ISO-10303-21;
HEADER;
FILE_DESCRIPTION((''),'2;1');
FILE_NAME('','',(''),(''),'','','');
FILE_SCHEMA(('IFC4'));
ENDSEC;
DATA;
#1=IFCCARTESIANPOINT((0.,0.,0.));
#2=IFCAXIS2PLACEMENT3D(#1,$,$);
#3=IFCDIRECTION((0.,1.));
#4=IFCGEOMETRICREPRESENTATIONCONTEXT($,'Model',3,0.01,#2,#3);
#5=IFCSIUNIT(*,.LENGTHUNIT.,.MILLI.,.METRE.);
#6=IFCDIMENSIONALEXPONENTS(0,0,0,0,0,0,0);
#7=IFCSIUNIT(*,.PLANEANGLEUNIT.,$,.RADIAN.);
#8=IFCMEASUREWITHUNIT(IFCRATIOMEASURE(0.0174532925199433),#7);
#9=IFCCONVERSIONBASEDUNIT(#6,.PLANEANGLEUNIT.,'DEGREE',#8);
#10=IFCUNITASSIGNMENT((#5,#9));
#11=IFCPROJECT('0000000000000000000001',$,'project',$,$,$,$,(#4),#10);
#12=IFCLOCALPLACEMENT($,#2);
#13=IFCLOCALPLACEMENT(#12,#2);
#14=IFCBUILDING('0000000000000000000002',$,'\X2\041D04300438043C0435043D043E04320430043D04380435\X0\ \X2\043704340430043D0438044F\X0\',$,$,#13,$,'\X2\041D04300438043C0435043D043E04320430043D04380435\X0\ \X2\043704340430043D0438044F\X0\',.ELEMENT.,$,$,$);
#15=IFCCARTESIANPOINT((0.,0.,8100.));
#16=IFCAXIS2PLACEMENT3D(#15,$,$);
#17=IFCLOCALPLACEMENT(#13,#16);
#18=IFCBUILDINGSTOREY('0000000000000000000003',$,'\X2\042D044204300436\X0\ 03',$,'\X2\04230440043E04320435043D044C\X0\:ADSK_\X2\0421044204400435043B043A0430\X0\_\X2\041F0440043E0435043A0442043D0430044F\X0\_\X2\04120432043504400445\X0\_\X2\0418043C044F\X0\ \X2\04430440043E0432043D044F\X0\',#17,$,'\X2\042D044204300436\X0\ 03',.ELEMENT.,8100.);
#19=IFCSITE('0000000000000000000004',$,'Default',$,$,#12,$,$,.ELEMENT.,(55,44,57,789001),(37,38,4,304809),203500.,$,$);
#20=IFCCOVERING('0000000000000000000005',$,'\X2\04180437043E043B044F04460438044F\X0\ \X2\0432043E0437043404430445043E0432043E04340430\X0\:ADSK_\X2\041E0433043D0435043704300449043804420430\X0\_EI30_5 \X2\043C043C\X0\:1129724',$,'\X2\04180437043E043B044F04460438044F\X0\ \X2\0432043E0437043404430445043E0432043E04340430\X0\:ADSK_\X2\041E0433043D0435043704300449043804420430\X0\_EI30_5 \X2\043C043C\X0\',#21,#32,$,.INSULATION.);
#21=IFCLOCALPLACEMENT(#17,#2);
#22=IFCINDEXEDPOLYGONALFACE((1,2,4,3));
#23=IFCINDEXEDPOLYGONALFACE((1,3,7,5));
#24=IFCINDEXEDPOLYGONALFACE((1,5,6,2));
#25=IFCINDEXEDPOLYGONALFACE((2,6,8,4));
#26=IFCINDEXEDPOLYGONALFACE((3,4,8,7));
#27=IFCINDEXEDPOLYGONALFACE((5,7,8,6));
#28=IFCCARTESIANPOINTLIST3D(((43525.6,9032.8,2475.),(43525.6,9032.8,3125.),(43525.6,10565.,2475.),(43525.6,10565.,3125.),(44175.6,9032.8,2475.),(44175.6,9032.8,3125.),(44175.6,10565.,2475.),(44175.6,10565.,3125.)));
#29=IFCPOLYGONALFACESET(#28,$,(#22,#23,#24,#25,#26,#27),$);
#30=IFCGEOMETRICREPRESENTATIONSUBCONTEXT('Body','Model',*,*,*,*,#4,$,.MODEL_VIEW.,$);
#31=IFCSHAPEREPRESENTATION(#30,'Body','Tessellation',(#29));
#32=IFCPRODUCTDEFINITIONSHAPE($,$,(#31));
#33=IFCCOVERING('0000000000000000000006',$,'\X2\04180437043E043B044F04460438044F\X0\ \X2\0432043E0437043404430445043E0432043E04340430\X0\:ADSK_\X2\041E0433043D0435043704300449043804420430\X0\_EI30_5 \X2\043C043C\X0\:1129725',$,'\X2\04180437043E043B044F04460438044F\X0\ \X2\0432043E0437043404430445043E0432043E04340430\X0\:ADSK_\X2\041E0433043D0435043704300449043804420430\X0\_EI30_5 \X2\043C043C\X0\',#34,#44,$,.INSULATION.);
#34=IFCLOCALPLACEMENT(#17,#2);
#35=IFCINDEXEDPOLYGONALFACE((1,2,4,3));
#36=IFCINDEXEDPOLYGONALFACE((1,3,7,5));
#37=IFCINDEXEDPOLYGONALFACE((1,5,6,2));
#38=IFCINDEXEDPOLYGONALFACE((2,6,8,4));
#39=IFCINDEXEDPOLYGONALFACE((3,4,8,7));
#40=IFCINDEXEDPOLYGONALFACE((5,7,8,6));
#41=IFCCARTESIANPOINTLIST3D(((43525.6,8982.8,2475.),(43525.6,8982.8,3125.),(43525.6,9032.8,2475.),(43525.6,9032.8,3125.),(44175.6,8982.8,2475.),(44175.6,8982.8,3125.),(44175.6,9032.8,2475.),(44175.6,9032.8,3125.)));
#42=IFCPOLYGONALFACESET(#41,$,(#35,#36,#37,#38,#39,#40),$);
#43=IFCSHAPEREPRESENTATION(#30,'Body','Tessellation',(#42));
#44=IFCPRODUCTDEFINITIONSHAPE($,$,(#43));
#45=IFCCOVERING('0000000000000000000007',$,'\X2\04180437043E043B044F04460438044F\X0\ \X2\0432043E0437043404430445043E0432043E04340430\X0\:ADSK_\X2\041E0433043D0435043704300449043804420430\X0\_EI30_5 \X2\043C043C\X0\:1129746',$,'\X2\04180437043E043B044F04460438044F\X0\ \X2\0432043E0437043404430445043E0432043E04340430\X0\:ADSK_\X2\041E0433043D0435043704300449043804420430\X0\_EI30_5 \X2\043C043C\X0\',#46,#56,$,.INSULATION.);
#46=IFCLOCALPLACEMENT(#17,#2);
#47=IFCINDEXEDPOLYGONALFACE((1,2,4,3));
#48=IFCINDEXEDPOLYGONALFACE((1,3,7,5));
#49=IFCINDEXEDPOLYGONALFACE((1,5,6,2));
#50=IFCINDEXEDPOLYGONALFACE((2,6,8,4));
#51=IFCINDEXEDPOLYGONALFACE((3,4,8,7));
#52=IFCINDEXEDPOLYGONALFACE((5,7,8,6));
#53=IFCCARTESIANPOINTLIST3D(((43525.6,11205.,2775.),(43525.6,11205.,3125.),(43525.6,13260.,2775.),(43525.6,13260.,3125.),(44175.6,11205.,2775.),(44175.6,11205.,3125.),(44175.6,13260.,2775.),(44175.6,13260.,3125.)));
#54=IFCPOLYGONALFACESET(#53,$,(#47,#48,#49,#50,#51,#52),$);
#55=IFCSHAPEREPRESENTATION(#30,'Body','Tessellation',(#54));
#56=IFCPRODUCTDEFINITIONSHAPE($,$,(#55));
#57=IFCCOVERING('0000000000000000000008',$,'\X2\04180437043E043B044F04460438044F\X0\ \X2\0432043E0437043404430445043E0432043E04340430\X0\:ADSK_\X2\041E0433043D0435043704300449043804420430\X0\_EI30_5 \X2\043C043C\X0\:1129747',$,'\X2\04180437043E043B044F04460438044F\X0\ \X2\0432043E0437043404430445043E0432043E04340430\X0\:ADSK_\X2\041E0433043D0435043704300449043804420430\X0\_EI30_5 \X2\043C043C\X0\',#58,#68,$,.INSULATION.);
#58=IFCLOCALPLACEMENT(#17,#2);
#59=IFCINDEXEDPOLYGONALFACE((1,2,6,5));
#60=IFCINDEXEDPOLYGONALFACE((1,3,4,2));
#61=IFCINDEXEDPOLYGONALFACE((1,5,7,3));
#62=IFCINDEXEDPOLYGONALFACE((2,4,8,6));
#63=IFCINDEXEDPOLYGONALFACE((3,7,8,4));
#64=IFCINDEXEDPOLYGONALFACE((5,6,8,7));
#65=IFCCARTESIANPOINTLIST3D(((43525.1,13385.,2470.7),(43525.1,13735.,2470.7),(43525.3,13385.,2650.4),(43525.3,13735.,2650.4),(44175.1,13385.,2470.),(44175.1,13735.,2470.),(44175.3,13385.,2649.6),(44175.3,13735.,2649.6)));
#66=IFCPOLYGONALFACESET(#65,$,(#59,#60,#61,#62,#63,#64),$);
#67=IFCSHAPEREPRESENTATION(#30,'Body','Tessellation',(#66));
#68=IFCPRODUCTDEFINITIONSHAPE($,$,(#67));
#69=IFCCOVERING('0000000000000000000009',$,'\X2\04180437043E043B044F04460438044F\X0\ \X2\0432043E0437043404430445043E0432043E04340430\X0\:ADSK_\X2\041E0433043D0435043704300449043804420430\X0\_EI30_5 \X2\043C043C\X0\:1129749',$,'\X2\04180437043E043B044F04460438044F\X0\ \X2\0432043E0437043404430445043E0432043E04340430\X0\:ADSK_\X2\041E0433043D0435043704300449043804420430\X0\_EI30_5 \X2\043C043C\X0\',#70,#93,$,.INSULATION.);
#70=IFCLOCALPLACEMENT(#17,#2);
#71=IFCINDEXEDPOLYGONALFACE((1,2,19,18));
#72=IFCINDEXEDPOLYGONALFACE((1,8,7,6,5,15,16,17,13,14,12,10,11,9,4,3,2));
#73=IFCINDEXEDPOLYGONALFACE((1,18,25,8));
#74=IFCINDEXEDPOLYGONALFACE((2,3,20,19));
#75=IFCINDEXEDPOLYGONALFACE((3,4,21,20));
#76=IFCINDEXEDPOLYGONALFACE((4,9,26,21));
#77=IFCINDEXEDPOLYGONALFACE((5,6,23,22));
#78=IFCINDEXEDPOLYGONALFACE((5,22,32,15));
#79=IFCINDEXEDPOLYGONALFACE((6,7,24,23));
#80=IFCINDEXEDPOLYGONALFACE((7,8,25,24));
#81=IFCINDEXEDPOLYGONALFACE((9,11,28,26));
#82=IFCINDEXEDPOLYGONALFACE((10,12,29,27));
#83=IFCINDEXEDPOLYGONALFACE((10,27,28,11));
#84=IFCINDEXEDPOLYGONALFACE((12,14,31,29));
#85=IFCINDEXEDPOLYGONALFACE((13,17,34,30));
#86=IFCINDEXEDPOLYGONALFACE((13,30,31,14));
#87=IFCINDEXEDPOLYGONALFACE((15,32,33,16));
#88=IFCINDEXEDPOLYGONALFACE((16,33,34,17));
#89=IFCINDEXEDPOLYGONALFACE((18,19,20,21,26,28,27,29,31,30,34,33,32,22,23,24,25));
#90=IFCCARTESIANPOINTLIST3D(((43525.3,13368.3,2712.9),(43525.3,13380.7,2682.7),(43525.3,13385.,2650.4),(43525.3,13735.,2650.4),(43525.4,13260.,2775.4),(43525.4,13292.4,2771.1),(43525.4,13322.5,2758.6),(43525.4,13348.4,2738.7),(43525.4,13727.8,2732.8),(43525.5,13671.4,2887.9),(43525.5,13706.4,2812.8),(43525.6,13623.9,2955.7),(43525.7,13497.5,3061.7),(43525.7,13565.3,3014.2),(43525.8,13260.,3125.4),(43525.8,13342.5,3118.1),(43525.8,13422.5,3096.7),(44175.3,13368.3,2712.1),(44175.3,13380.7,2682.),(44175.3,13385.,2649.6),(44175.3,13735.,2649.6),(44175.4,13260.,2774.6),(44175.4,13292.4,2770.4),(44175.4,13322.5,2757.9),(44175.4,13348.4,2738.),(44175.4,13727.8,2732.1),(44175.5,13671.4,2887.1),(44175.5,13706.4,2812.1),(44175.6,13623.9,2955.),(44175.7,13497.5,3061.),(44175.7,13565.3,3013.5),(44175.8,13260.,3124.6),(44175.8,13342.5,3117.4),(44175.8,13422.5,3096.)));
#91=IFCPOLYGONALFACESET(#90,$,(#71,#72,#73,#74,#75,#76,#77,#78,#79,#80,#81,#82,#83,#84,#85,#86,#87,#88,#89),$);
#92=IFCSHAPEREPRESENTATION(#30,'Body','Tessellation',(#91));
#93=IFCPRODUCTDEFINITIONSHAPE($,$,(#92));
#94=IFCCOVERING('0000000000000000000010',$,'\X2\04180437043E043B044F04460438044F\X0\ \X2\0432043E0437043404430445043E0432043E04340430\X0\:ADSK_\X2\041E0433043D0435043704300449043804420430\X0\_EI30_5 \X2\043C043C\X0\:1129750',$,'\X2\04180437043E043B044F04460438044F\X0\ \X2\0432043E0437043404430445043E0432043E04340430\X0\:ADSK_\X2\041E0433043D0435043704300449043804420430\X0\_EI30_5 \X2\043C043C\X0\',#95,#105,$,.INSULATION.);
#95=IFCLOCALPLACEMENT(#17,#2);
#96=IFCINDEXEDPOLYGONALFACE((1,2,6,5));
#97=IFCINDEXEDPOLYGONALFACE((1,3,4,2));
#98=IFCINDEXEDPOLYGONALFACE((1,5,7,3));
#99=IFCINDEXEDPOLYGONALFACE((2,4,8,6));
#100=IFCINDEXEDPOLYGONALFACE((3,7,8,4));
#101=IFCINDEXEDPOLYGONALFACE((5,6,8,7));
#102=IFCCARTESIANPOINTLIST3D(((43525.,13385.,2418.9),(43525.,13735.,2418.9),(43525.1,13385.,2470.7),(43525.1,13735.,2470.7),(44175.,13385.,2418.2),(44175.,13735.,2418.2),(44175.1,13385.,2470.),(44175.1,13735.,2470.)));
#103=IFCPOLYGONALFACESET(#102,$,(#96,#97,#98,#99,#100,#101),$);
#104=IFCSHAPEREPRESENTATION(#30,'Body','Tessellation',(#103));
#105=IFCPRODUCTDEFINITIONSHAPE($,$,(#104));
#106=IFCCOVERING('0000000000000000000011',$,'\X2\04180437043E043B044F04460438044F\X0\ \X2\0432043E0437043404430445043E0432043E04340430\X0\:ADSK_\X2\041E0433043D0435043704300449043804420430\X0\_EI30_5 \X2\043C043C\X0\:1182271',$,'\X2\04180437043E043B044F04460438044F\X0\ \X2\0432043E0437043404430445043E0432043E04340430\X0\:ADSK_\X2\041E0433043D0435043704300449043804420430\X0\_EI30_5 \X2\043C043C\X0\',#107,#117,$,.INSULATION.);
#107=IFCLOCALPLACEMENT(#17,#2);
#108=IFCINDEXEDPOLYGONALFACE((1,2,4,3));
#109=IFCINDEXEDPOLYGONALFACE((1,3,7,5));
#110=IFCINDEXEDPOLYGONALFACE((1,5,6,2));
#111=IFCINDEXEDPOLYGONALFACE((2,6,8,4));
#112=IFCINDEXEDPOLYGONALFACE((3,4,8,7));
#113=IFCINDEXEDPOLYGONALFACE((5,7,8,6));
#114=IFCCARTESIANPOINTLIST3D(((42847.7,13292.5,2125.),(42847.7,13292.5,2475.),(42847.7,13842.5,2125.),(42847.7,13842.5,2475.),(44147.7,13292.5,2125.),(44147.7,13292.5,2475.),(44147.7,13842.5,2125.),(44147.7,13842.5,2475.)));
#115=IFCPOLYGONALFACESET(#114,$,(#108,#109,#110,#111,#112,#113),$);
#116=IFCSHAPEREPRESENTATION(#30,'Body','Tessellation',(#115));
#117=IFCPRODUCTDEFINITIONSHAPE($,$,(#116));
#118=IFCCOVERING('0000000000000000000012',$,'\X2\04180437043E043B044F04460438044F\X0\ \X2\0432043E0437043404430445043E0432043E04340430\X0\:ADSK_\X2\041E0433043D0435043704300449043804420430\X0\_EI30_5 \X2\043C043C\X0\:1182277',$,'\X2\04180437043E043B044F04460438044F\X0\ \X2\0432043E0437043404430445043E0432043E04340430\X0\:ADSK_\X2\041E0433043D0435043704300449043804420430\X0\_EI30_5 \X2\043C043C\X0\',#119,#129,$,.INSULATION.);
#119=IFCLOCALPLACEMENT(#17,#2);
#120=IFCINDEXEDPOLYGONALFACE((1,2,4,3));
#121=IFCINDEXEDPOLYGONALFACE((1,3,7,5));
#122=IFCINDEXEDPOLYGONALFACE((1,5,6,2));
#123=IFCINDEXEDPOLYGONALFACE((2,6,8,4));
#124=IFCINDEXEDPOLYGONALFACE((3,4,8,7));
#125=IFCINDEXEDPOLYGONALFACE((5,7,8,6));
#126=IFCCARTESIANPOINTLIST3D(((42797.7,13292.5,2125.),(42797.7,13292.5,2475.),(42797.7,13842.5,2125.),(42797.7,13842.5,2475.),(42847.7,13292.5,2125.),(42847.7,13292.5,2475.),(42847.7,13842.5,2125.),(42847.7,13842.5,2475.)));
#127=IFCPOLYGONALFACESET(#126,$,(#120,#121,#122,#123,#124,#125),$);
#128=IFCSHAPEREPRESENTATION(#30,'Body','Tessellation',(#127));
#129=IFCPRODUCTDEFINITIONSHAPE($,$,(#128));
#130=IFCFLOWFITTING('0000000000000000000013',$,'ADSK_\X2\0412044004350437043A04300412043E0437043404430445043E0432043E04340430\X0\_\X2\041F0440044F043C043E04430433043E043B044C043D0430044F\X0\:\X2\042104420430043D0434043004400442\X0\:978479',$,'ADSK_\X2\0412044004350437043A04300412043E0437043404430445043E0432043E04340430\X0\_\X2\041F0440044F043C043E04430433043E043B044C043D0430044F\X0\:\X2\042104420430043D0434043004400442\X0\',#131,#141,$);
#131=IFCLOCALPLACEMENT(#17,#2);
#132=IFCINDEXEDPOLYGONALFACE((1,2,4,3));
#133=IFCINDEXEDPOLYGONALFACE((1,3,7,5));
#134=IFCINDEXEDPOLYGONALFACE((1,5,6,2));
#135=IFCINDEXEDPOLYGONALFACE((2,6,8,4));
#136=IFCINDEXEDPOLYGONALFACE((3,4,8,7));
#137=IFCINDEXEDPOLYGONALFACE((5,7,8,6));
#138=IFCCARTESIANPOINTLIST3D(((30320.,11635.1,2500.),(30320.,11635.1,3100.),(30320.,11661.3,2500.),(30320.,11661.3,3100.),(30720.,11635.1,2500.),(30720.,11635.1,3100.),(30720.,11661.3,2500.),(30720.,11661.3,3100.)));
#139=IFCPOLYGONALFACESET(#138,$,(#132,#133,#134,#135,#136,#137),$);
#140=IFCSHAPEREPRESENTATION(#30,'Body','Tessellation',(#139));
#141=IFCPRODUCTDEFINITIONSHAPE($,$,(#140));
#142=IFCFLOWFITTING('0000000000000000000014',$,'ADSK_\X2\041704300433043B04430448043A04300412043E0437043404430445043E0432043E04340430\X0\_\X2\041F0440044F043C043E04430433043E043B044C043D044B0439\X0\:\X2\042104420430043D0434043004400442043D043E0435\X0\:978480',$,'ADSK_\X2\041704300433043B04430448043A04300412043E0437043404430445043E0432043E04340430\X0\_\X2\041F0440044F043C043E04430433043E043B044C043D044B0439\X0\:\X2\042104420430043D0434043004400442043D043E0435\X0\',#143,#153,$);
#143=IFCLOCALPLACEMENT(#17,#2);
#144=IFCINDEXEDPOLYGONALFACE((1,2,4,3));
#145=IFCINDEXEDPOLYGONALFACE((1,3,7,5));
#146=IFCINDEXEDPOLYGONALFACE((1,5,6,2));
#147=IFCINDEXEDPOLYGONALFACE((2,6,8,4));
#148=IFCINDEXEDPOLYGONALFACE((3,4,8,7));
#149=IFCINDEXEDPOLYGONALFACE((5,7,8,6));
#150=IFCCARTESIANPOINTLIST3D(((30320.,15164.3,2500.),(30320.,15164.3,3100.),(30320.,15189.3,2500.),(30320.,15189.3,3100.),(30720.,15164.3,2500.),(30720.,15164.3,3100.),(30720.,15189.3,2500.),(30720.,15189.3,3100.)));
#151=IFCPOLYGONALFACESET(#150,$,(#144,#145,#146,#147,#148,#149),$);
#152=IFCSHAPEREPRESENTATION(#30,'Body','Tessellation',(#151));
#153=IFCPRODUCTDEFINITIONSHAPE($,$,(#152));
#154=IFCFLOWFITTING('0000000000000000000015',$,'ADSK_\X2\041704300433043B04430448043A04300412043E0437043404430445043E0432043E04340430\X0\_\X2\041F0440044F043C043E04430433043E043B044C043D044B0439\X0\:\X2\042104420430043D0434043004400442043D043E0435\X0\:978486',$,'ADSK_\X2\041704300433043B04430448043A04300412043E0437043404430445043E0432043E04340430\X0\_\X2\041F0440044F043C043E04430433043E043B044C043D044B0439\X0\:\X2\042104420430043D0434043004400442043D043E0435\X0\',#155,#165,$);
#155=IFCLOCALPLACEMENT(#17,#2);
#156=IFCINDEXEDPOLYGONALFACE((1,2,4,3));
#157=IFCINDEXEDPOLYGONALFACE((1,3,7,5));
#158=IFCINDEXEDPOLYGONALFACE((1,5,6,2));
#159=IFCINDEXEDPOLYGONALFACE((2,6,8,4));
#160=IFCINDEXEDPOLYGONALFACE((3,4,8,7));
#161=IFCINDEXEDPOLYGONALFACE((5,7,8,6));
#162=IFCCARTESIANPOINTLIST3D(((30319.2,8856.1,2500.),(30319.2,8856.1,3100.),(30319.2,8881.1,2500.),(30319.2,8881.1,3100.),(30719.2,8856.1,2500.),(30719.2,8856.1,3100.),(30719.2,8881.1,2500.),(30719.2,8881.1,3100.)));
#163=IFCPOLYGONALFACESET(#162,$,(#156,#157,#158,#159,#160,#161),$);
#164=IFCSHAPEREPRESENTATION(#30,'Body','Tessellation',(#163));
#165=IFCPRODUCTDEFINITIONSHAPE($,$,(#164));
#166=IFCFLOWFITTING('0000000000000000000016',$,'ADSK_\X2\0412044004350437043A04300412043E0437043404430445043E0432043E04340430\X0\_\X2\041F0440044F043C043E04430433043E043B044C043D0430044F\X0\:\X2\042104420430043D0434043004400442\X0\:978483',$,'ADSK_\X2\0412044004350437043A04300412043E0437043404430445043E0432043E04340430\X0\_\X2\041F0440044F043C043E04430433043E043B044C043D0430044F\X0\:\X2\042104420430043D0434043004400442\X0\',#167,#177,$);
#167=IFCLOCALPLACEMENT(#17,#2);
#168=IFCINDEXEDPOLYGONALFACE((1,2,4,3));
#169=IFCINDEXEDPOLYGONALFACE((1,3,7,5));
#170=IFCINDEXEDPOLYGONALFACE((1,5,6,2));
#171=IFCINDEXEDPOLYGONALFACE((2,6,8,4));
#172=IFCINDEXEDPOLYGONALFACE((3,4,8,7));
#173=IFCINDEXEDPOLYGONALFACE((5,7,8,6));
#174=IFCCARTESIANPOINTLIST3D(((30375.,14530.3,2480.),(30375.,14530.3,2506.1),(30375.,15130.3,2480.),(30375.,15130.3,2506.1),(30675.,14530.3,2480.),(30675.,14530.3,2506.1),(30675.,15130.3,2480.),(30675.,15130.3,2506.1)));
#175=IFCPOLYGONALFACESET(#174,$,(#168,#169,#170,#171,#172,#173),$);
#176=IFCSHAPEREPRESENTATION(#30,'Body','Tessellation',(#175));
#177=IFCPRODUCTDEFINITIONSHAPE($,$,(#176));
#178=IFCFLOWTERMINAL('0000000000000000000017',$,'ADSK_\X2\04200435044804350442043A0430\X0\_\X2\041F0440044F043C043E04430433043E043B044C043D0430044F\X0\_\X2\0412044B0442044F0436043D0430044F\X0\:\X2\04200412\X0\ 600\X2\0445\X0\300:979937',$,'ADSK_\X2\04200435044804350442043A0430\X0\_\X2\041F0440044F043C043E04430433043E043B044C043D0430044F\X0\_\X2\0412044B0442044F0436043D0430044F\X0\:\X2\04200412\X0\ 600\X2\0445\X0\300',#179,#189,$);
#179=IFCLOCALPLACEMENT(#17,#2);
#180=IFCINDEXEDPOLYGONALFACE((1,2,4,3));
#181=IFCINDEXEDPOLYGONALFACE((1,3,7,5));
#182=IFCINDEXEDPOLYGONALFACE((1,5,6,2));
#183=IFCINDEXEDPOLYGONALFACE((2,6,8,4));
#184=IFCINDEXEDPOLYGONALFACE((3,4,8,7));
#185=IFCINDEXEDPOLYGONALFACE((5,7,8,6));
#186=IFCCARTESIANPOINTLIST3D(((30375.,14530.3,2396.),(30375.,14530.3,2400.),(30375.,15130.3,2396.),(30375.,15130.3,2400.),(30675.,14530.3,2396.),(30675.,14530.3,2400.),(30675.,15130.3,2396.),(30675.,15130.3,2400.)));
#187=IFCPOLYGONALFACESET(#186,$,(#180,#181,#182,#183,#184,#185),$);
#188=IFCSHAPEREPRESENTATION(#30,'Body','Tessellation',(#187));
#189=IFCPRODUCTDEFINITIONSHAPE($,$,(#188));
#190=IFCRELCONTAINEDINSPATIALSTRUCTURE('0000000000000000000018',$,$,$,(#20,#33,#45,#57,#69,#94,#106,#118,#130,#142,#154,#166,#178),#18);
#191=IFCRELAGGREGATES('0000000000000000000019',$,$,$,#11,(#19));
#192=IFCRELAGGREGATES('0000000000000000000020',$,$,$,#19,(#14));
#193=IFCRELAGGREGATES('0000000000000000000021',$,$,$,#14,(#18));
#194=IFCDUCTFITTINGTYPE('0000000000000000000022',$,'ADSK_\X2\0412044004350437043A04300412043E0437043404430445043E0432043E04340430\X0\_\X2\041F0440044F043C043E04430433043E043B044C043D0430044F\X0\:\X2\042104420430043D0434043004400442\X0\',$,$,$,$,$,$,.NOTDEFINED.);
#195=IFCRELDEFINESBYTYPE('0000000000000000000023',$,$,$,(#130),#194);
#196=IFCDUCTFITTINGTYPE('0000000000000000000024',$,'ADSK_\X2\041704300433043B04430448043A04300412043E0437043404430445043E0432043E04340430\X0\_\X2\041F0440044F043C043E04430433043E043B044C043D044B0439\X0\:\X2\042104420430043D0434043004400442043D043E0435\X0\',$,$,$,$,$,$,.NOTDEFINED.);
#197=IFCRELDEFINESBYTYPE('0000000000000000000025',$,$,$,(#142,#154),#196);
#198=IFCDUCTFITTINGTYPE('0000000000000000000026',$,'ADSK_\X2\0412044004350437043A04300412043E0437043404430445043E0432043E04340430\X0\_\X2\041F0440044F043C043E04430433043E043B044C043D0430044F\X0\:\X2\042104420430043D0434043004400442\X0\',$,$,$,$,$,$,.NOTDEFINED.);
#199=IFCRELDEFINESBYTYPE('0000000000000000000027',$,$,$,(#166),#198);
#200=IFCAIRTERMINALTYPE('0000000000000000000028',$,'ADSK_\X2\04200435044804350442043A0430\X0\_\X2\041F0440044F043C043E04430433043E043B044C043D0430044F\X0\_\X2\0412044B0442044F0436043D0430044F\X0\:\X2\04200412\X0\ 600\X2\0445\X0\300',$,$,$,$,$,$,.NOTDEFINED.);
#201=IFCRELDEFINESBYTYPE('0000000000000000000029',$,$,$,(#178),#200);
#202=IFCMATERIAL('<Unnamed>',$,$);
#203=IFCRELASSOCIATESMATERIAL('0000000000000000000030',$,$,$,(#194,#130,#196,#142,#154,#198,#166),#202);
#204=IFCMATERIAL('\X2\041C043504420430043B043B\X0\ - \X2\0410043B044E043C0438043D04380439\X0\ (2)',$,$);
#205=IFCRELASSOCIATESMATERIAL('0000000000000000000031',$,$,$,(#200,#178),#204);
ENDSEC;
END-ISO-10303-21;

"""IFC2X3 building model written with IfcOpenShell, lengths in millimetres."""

from ifc_helpers import new_model, entity, si_unit, converted_unit, direction, frame, frame_2d, origin, origin_2d_with_axis, place, context, subcontext, project, spatial, polyline, circle_curve, parameter, trimmed, segment, composite_curve, rectangle, outline, extrude, source, transform, mapped, material, type_object, type_shapes, element, save


model = new_model("IFC2X3")

# Units and contexts
model_context = context("Model", 3, precision=0.01, world=origin(), true_north=direction((0.0, 1.0)))
body_context = subcontext(model_context, "Body", "Model", "MODEL_VIEW")
ifc_project = project(units=[si_unit("LENGTHUNIT", "METRE", prefix="MILLI"), converted_unit("PLANEANGLEUNIT", "DEGREE", entity("IfcRatioMeasure", 0.0174532925199433), si_unit("PLANEANGLEUNIT", "RADIAN"), dimensions=[0, 0, 0, 0, 0, 0, 0])], contexts=[model_context])

# Site, building, storey
site_placement = place(None, frame((0.0, 0.0, 0.0)))
site = spatial("IfcSite", under=ifc_project, at=site_placement, Name="Default", CompositionType="ELEMENT", RefLatitude=(55, 44, 57, 789001), RefLongitude=(37, 38, 4, 304809), RefElevation=203500.0)
building_placement = place(site_placement, origin())
building = spatial("IfcBuilding", under=site, at=building_placement, Name="Наименование здания", LongName="Наименование здания", CompositionType="ELEMENT")
storey_placement = place(building_placement, frame((0.0, 0.0, 8100.0)))
storey = spatial("IfcBuildingStorey", under=building, at=storey_placement, Name="Этаж 03", ObjectType="Уровень:ADSK_Стрелка_Проектная_Вверх_Имя уровня", LongName="Этаж 03", CompositionType="ELEMENT", Elevation=8100.0)

# Coverings
covering_1_placement = place(storey_placement, frame((43525.6, 9032.8, 2475.0)))
element("IfcCovering", 1, at=covering_1_placement, inside=storey, Name="Изоляция воздуховода:ADSK_Огнезащита_EI30_5 мм:1129724", ObjectType="Изоляция воздуховода:ADSK_Огнезащита_EI30_5 мм", PredefinedType="INSULATION", context=body_context, shape_type="SweptSolid", body=[
    extrude(rectangle(XDim=1532.2, YDim=650.0, at=frame_2d((0.0, 0.0), x_axis=(1.0, 0.0))), frame((325.0, 766.1, 0.0), z_axis=(0.0, 0.0, 1.0), x_axis=(0.0, 1.0, 0.0)), (0.0, 0.0, 1.0), 650.0),
])
covering_2_placement = place(storey_placement, frame((43525.6, 8982.8, 2475.0)))
element("IfcCovering", 2, at=covering_2_placement, inside=storey, Name="Изоляция воздуховода:ADSK_Огнезащита_EI30_5 мм:1129725", ObjectType="Изоляция воздуховода:ADSK_Огнезащита_EI30_5 мм", PredefinedType="INSULATION", context=body_context, shape_type="SweptSolid", body=[
    extrude(rectangle(XDim=50.0, YDim=650.0, at=frame_2d((0.0, 0.0), x_axis=(1.0, 0.0))), frame((325.0, 25.0, 0.0), z_axis=(0.0, 0.0, 1.0), x_axis=(0.0, 1.0, 0.0)), (0.0, 0.0, 1.0), 650.0),
])
covering_3_placement = place(storey_placement, frame((43525.6, 11205.0, 2775.0)))
element("IfcCovering", 3, at=covering_3_placement, inside=storey, Name="Изоляция воздуховода:ADSK_Огнезащита_EI30_5 мм:1129746", ObjectType="Изоляция воздуховода:ADSK_Огнезащита_EI30_5 мм", PredefinedType="INSULATION", context=body_context, shape_type="SweptSolid", body=[
    extrude(rectangle(XDim=2055.0, YDim=650.0, at=frame_2d((0.0, 0.0), x_axis=(1.0, 0.0))), frame((325.0, 1027.5, 0.0), z_axis=(0.0, 0.0, 1.0), x_axis=(0.0, 1.0, 0.0)), (0.0, 0.0, 1.0), 350.0),
])
covering_4_placement = place(storey_placement, frame((43525.1, 13385.0, 2470.0)))
element("IfcCovering", 4, at=covering_4_placement, inside=storey, Name="Изоляция воздуховода:ADSK_Огнезащита_EI30_5 мм:1129747", ObjectType="Изоляция воздуховода:ADSK_Огнезащита_EI30_5 мм", PredefinedType="INSULATION", context=body_context, shape_type="SweptSolid", body=[
    extrude(rectangle(XDim=650.0, YDim=350.0, at=origin_2d_with_axis()), frame((325.0, 175.0, 0.4), z_axis=(0.0011, 0.0, 0.999999), x_axis=(-0.999999, 0.0, 0.0011)), (0.0, 0.0, 1.0), 179.7),
])
covering_5_placement = place(storey_placement, frame((43523.7, 13258.4, 2648.0)))
element("IfcCovering", 5, at=covering_5_placement, inside=storey, Name="Изоляция воздуховода:ADSK_Огнезащита_EI30_5 мм:1129749", ObjectType="Изоляция воздуховода:ADSK_Огнезащита_EI30_5 мм", PredefinedType="INSULATION", context=body_context, shape_type="SweptSolid", body=[
    extrude(outline(composite_curve([segment(polyline([(-150.0, 25.0), (-150.0, -325.0)]), True, "CONTINUOUS"), segment(trimmed(circle_curve(frame_2d((-150.0, 150.0), x_axis=(1.0, 0.0)), 475.0), [parameter(270.0)], [parameter(0.0)], True, "PARAMETER"), True, "CONTINUOUS"), segment(polyline([(325.0, 150.0), (-25.0, 150.0)]), True, "CONTINUOUS"), segment(trimmed(circle_curve(frame_2d((-150.0, 150.0), x_axis=(1.0, 0.0)), 125.0), [parameter(270.0)], [parameter(360.0)], True, "PARAMETER"), False, "CONTINUOUS")], self_intersect=False)), frame((651.8, 151.6, 151.6), z_axis=(0.999999, 0.0, -0.0011), x_axis=(0.0011, 0.0, 0.999999)), (0.0, 0.0, -1.0), 650.0),
])
covering_6_placement = place(storey_placement, frame((43525.0, 13385.0, 2418.2)))
element("IfcCovering", 6, at=covering_6_placement, inside=storey, Name="Изоляция воздуховода:ADSK_Огнезащита_EI30_5 мм:1129750", ObjectType="Изоляция воздуховода:ADSK_Огнезащита_EI30_5 мм", PredefinedType="INSULATION", context=body_context, shape_type="SweptSolid", body=[
    extrude(rectangle(XDim=650.0, YDim=350.0, at=frame_2d((0.0, 0.0), x_axis=(0.0, 1.0))), frame((325.0, 175.0, 0.4), z_axis=(0.0011, 0.0, 0.999999), x_axis=(0.0, -1.0, 0.0)), (0.0, 0.0, 1.0), 51.8),
])
covering_7_placement = place(storey_placement, frame((42847.7, 13292.5, 2125.0)))
element("IfcCovering", 7, at=covering_7_placement, inside=storey, Name="Изоляция воздуховода:ADSK_Огнезащита_EI30_5 мм:1182271", ObjectType="Изоляция воздуховода:ADSK_Огнезащита_EI30_5 мм", PredefinedType="INSULATION", context=body_context, shape_type="SweptSolid", body=[
    extrude(rectangle(XDim=1300.0, YDim=550.0, at=frame_2d((0.0, 0.0), x_axis=(1.0, 0.0))), frame((650.0, 275.0, 0.0), z_axis=(0.0, 0.0, 1.0), x_axis=(-1.0, 0.0, 0.0)), (0.0, 0.0, 1.0), 350.0),
])
covering_8_placement = place(storey_placement, frame((42797.7, 13292.5, 2125.0)))
element("IfcCovering", 8, at=covering_8_placement, inside=storey, Name="Изоляция воздуховода:ADSK_Огнезащита_EI30_5 мм:1182277", ObjectType="Изоляция воздуховода:ADSK_Огнезащита_EI30_5 мм", PredefinedType="INSULATION", context=body_context, shape_type="SweptSolid", body=[
    extrude(rectangle(XDim=50.0, YDim=550.0, at=frame_2d((0.0, 0.0), x_axis=(1.0, 0.0))), frame((25.0, 275.0, 0.0)), (0.0, 0.0, 1.0), 350.0),
])

# Flow fittings
ifc_material_1 = material(Name="<Unnamed>")
duct_fitting_type_1 = type_object("IfcDuctFittingType", Name="ADSK_ВрезкаВоздуховода_Прямоугольная:Стандарт", PredefinedType="NOTDEFINED", material=ifc_material_1)
shared_shape_1 = source(origin(), body_context, "Body", "SweptSolid", [
    extrude(rectangle(XDim=26.2, YDim=600.0, at=frame_2d((0.0, 0.0), x_axis=(1.0, 0.0))), frame((7.0, 0.0, -200.0)), (0.0, 0.0, 1.0), 400.0),
])
type_shapes(duct_fitting_type_1, [shared_shape_1])
flow_fitting_1_placement = place(storey_placement, frame((30520.0, 11641.2, 2800.0), z_axis=(1.0, 0.0, 0.0), x_axis=(0.0, 1.0, 0.0)))
element("IfcFlowFitting", 9, at=flow_fitting_1_placement, inside=storey, type_object=duct_fitting_type_1, material=ifc_material_1, Name="ADSK_ВрезкаВоздуховода_Прямоугольная:Стандарт:978479", ObjectType="ADSK_ВрезкаВоздуховода_Прямоугольная:Стандарт", context=body_context, shape_type="MappedRepresentation", body=[
    mapped(shared_shape_1, transform((0.0, 0.0, 0.0), scale=1.0)),
])
duct_fitting_type_2 = type_object("IfcDuctFittingType", Name="ADSK_ЗаглушкаВоздуховода_Прямоугольный:Стандартное", PredefinedType="NOTDEFINED", material=ifc_material_1)
shared_shape_2 = source(origin(), body_context, "Body", "SweptSolid", [
    extrude(rectangle(XDim=25.0, YDim=400.0, at=frame_2d((0.0, 0.0), x_axis=(1.0, 0.0))), frame((12.5, 0.0, -300.0)), (0.0, 0.0, 1.0), 600.0),
])
type_shapes(duct_fitting_type_2, [shared_shape_2])
for number, where, z_axis, x_axis, name in (
    (10, (30520.0, 15164.3, 2800.0), (0.0, 0.0, 1.0), (0.0, 1.0, 0.0), "ADSK_ЗаглушкаВоздуховода_Прямоугольный:Стандартное:978480"),
    (11, (30519.2, 8881.1, 2800.0), (0.0, 0.0, 1.0), (0.0, -1.0, 0.0), "ADSK_ЗаглушкаВоздуховода_Прямоугольный:Стандартное:978486"),
):
    element("IfcFlowFitting", number, at=place(storey_placement, frame(where, z_axis=z_axis, x_axis=x_axis)), inside=storey, type_object=duct_fitting_type_2, material=ifc_material_1, Name=name, ObjectType="ADSK_ЗаглушкаВоздуховода_Прямоугольный:Стандартное", context=body_context, shape_type="MappedRepresentation", body=[
        mapped(shared_shape_2, transform((0.0, 0.0, 0.0), scale=1.0)),
    ])
duct_fitting_type_3 = type_object("IfcDuctFittingType", Name="ADSK_ВрезкаВоздуховода_Прямоугольная:Стандарт", PredefinedType="NOTDEFINED", material=ifc_material_1)
shared_shape_3 = source(origin(), body_context, "Body", "SweptSolid", [
    extrude(rectangle(XDim=26.1, YDim=600.0, at=frame_2d((0.0, 0.0), x_axis=(1.0, 0.0))), frame((7.0, 0.0, -150.0)), (0.0, 0.0, 1.0), 300.0),
])
type_shapes(duct_fitting_type_3, [shared_shape_3])
flow_fitting_2_placement = place(storey_placement, frame((30525.0, 14830.3, 2500.0), z_axis=(-1.0, 0.0, 0.0), x_axis=(0.0, 0.0, -1.0)))
element("IfcFlowFitting", 12, at=flow_fitting_2_placement, inside=storey, type_object=duct_fitting_type_3, material=ifc_material_1, Name="ADSK_ВрезкаВоздуховода_Прямоугольная:Стандарт:978483", ObjectType="ADSK_ВрезкаВоздуховода_Прямоугольная:Стандарт", context=body_context, shape_type="MappedRepresentation", body=[
    mapped(shared_shape_3, transform((0.0, 0.0, 0.0), scale=1.0)),
])

# Flow terminal
ifc_material_2 = material(Name="Металл - Алюминий (2)")
air_terminal_type = type_object("IfcAirTerminalType", Name="ADSK_Решетка_Прямоугольная_Вытяжная:РВ 600х300", PredefinedType="NOTDEFINED", material=ifc_material_2)
shared_shape_4 = source(origin(), body_context, "Body", "SweptSolid", [
    extrude(rectangle(XDim=4.0, YDim=600.0, at=origin_2d_with_axis()), frame((0.0, -2.0, -150.0), z_axis=(0.0, 0.0, 1.0), x_axis=(0.0, 1.0, 0.0)), (0.0, 0.0, 1.0), 300.0),
])
type_shapes(air_terminal_type, [shared_shape_4])
flow_terminal_placement = place(storey_placement, frame((30525.0, 14830.3, 2400.0), z_axis=(-1.0, 0.0, 0.0), x_axis=(0.0, -1.0, 0.0)))
element("IfcFlowTerminal", 13, at=flow_terminal_placement, inside=storey, type_object=air_terminal_type, material=ifc_material_2, Name="ADSK_Решетка_Прямоугольная_Вытяжная:РВ 600х300:979937", ObjectType="ADSK_Решетка_Прямоугольная_Вытяжная:РВ 600х300", context=body_context, shape_type="MappedRepresentation", body=[
    mapped(shared_shape_4, transform((0.0, 0.0, 0.0), scale=1.0)),
])

save(model, "model.ifc")
